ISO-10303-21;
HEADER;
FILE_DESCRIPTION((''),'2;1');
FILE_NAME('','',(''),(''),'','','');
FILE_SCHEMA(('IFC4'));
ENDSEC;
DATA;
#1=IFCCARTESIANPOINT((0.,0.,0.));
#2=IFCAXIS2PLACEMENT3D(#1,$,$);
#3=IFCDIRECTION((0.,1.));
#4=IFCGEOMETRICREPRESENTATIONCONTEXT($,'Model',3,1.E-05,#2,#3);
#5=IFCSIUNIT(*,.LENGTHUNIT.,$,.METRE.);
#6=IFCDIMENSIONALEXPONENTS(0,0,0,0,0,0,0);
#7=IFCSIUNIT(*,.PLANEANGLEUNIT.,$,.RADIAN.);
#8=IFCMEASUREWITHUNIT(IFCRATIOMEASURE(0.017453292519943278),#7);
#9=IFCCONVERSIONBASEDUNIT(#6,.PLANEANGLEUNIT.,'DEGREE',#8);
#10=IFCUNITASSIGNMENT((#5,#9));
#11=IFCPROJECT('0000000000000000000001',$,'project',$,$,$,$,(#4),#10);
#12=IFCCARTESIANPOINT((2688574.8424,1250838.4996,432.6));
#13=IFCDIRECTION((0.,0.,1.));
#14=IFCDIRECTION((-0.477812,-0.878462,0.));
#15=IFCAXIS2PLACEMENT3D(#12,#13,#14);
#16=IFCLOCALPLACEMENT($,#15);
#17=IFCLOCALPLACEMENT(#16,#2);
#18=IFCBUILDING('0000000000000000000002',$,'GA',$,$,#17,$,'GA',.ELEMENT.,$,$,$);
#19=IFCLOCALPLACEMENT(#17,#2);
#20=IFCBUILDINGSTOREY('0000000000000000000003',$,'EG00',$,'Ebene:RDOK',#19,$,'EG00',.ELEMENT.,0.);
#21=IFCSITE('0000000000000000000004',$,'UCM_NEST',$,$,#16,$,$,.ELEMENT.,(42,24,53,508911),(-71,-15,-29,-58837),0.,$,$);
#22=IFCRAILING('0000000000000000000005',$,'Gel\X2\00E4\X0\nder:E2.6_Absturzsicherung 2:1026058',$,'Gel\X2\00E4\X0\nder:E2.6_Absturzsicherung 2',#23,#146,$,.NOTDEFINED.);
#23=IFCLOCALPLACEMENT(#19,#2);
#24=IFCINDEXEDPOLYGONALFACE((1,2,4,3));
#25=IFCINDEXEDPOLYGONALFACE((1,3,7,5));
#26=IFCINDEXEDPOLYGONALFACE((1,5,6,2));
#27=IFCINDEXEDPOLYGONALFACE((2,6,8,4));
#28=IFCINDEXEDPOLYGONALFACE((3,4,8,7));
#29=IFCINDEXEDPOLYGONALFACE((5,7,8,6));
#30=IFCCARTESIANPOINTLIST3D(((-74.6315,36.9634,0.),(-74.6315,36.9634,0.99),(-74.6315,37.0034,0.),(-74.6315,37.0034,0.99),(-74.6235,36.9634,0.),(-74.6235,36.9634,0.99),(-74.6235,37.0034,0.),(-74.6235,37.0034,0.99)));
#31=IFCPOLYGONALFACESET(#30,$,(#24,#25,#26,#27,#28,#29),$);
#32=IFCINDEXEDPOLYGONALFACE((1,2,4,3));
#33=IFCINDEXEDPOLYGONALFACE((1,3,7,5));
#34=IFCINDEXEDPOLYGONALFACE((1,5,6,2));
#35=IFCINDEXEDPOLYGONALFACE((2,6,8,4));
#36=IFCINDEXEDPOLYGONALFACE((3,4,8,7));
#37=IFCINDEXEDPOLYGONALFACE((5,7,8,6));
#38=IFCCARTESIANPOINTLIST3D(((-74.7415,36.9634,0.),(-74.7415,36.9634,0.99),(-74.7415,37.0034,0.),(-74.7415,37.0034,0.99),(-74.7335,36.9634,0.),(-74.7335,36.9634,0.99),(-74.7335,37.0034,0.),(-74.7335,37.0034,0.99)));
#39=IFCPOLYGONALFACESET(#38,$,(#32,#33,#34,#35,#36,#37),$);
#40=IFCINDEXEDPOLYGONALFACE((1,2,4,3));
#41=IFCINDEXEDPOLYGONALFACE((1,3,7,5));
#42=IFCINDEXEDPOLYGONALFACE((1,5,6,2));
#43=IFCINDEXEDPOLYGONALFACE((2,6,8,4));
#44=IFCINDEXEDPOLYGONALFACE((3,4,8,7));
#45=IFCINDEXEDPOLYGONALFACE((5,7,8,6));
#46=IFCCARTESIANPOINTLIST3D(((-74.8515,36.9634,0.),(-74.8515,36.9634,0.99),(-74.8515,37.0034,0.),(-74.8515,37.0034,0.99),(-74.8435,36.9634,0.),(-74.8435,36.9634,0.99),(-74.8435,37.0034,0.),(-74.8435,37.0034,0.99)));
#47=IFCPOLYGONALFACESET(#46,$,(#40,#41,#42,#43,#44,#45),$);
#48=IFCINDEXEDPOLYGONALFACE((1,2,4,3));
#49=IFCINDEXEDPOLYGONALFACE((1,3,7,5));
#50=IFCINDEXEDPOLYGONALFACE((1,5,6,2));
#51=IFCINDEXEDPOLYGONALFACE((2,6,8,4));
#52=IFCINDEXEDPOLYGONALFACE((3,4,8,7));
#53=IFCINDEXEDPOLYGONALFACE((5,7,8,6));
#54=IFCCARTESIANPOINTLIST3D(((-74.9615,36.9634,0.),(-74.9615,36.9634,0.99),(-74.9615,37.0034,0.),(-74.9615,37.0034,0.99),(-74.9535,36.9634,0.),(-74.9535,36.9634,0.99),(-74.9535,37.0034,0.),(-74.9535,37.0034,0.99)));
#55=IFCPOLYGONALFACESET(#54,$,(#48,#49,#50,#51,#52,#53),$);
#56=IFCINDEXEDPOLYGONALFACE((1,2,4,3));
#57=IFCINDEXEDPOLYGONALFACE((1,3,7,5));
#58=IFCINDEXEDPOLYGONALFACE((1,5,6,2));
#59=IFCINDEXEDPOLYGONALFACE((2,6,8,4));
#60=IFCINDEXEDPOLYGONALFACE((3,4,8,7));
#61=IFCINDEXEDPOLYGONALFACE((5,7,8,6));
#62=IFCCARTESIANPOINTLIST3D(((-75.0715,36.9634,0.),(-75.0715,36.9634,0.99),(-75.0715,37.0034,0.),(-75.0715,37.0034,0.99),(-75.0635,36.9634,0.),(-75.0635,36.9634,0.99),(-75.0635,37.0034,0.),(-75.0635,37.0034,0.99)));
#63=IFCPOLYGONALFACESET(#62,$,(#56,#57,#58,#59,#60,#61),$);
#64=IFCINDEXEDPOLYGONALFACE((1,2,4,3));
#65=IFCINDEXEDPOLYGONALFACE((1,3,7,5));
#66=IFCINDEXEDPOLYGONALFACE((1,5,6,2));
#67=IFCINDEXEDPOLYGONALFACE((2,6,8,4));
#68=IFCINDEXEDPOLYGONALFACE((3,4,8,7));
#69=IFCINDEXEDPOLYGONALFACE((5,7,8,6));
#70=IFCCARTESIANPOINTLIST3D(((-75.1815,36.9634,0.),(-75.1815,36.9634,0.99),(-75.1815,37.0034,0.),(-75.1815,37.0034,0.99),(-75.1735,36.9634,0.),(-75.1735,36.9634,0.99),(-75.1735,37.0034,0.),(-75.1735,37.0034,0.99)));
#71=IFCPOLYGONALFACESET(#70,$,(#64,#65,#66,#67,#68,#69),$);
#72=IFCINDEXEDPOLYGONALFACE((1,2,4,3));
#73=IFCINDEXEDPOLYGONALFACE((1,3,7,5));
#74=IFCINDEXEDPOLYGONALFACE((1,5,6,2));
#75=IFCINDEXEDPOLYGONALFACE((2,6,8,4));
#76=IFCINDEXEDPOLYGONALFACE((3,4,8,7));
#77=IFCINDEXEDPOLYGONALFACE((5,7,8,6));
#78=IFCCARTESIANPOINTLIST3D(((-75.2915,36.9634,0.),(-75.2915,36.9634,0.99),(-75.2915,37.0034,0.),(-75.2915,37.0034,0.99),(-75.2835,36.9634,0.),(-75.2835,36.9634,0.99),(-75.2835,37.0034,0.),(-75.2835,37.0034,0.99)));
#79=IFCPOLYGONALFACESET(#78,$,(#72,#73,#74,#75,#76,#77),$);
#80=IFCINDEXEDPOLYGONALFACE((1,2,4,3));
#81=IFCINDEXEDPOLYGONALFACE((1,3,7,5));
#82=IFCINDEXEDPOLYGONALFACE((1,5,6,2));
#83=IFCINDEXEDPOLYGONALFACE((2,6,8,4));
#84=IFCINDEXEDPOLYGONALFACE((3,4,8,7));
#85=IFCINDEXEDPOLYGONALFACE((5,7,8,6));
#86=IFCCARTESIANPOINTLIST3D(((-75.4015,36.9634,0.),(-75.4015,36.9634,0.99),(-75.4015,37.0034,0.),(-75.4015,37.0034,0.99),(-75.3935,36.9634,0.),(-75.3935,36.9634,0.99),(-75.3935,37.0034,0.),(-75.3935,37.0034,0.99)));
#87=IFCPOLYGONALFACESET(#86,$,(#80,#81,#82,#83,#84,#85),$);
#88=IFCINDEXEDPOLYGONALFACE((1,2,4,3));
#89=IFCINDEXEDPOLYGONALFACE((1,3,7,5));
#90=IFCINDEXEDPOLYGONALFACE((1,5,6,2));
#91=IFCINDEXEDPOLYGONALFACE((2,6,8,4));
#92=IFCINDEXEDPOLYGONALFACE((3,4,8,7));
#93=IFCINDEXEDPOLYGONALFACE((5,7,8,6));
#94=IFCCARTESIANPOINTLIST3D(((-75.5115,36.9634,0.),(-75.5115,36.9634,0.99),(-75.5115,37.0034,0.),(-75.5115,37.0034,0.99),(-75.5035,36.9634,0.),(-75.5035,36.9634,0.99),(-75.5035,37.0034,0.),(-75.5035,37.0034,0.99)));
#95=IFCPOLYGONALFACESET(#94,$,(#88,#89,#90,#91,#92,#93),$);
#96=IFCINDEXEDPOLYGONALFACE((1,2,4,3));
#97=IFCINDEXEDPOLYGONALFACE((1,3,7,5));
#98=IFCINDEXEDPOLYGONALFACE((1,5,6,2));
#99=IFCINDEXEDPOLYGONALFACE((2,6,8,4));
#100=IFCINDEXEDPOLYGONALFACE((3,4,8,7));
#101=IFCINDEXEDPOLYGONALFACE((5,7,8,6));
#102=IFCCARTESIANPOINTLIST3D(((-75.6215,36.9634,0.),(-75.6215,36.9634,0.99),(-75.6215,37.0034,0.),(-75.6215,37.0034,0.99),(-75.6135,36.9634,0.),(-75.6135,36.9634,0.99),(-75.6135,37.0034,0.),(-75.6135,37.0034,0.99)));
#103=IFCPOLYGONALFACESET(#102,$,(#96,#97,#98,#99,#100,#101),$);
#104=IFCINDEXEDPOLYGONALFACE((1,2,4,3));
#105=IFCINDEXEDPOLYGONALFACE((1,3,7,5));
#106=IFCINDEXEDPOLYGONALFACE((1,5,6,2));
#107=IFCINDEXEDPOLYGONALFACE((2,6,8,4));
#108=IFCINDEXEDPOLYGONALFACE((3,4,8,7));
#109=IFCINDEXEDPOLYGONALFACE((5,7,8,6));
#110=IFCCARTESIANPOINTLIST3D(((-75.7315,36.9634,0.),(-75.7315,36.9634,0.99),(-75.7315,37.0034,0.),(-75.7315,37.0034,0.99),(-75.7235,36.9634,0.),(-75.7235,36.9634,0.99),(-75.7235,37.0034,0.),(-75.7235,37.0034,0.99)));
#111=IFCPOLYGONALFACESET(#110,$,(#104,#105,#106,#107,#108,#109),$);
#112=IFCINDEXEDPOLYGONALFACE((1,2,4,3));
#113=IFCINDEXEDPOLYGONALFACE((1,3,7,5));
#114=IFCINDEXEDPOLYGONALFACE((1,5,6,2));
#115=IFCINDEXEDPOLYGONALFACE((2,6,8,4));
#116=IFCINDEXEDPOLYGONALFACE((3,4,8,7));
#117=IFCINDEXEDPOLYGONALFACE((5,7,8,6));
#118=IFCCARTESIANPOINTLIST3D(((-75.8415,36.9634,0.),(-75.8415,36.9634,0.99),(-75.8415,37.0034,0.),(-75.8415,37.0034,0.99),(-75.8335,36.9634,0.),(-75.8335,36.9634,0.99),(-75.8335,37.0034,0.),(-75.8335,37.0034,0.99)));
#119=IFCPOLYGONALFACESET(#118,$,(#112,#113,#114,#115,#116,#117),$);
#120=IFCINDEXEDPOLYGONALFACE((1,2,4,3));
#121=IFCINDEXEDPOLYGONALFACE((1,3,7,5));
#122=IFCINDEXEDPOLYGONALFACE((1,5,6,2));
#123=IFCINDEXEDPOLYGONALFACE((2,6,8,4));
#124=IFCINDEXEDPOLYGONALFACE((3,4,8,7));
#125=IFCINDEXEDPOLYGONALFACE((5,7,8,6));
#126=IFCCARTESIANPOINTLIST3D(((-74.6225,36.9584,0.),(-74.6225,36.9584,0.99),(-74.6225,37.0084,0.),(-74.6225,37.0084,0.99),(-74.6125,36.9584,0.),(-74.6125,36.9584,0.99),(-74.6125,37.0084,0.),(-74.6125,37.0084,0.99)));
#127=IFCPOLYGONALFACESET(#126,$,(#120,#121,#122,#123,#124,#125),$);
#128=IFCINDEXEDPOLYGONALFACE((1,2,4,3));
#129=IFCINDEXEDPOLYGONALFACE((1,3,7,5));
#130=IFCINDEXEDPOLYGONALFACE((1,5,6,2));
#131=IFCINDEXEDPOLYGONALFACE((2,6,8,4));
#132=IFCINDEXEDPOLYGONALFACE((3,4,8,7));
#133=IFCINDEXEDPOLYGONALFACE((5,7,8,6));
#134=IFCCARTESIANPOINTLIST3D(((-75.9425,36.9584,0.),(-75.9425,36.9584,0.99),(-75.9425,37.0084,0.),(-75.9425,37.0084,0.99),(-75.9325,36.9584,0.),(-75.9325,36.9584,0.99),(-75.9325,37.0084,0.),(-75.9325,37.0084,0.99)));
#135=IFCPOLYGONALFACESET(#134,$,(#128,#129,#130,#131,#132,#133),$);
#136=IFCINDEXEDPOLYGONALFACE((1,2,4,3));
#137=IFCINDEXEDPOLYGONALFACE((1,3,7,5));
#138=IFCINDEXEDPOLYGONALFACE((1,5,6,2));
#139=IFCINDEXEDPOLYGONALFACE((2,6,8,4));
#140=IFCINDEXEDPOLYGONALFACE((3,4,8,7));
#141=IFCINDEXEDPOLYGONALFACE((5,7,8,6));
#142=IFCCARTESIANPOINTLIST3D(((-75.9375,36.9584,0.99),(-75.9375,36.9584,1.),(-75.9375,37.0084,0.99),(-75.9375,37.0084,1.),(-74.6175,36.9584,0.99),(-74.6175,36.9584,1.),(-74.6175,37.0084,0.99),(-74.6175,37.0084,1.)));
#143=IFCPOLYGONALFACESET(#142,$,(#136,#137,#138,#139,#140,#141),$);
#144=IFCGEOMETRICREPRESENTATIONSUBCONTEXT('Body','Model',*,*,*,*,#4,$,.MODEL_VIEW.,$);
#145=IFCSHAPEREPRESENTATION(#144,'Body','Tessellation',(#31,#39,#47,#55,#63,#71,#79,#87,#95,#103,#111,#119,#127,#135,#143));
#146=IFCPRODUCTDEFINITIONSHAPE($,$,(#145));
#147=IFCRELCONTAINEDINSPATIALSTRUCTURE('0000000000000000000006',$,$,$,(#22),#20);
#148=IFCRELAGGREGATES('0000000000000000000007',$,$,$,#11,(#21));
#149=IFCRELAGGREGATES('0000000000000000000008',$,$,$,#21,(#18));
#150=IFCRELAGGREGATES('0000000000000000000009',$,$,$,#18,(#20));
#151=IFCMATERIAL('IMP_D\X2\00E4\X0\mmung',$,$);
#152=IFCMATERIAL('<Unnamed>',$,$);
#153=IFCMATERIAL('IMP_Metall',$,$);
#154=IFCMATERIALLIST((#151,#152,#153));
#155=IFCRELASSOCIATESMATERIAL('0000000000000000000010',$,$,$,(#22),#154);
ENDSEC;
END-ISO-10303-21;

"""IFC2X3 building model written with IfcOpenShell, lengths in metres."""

from ifc_helpers import new_model, entity, si_unit, converted_unit, direction, frame, origin, origin_2d_with_axis, place, context, subcontext, project, spatial, rectangle, extrude, material, material_list, element, save


model = new_model("IFC2X3")

# Units and contexts
model_context = context("Model", 3, precision=1e-05, world=origin(), true_north=direction((0.0, 1.0)))
body_context = subcontext(model_context, "Body", "Model", "MODEL_VIEW")
ifc_project = project(units=[si_unit("LENGTHUNIT", "METRE"), converted_unit("PLANEANGLEUNIT", "DEGREE", entity("IfcRatioMeasure", 0.017453292519943278), si_unit("PLANEANGLEUNIT", "RADIAN"), dimensions=[0, 0, 0, 0, 0, 0, 0])], contexts=[model_context])

# Site, building, storey
site_placement = place(None, frame((2688574.8424, 1250838.4996, 432.6), z_axis=(0.0, 0.0, 1.0), x_axis=(-0.477812, -0.878462, 0.0)))
site = spatial("IfcSite", under=ifc_project, at=site_placement, Name="UCM_NEST", CompositionType="ELEMENT", RefLatitude=(42, 24, 53, 508911), RefLongitude=(-71, -15, -29, -58837), RefElevation=0.0)
building_placement = place(site_placement, origin())
building = spatial("IfcBuilding", under=site, at=building_placement, Name="GA", LongName="GA", CompositionType="ELEMENT")
storey_placement = place(building_placement, origin())
storey = spatial("IfcBuildingStorey", under=building, at=storey_placement, Name="EG00", ObjectType="Ebene:RDOK", LongName="EG00", CompositionType="ELEMENT", Elevation=0.0)

# Shared definitions
ifc_material_1 = material(Name="IMP_Dämmung")

# Railing
ifc_material_2 = material(Name="<Unnamed>")
ifc_material_3 = material(Name="IMP_Metall")
ifc_material_list = material_list([ifc_material_1, ifc_material_2, ifc_material_3])
railing_1_placement = place(storey_placement, origin())
element("IfcRailing", 1, at=railing_1_placement, inside=storey, material=ifc_material_list, Name="Geländer:E2.6_Absturzsicherung 2:1026058", ObjectType="Geländer:E2.6_Absturzsicherung 2", PredefinedType="NOTDEFINED", context=body_context, shape_type="SweptSolid", body=[
    extrude(rectangle(XDim=0.008, YDim=0.04, at=origin_2d_with_axis()), frame((-74.6275, 36.9834, 0.0)), (0.0, 0.0, 1.0), 0.99),
    extrude(rectangle(XDim=0.008, YDim=0.04, at=origin_2d_with_axis()), frame((-74.7375, 36.9834, 0.0)), (0.0, 0.0, 1.0), 0.99),
    extrude(rectangle(XDim=0.008, YDim=0.04, at=origin_2d_with_axis()), frame((-74.8475, 36.9834, 0.0)), (0.0, 0.0, 1.0), 0.99),
    extrude(rectangle(XDim=0.008, YDim=0.04, at=origin_2d_with_axis()), frame((-74.9575, 36.9834, 0.0)), (0.0, 0.0, 1.0), 0.99),
    extrude(rectangle(XDim=0.008, YDim=0.04, at=origin_2d_with_axis()), frame((-75.0675, 36.9834, 0.0)), (0.0, 0.0, 1.0), 0.99),
    extrude(rectangle(XDim=0.008, YDim=0.04, at=origin_2d_with_axis()), frame((-75.1775, 36.9834, 0.0)), (0.0, 0.0, 1.0), 0.99),
    extrude(rectangle(XDim=0.008, YDim=0.04, at=origin_2d_with_axis()), frame((-75.2875, 36.9834, 0.0)), (0.0, 0.0, 1.0), 0.99),
    extrude(rectangle(XDim=0.008, YDim=0.04, at=origin_2d_with_axis()), frame((-75.3975, 36.9834, 0.0)), (0.0, 0.0, 1.0), 0.99),
    extrude(rectangle(XDim=0.008, YDim=0.04, at=origin_2d_with_axis()), frame((-75.5075, 36.9834, 0.0)), (0.0, 0.0, 1.0), 0.99),
    extrude(rectangle(XDim=0.008, YDim=0.04, at=origin_2d_with_axis()), frame((-75.6175, 36.9834, 0.0)), (0.0, 0.0, 1.0), 0.99),
    extrude(rectangle(XDim=0.008, YDim=0.04, at=origin_2d_with_axis()), frame((-75.7275, 36.9834, 0.0)), (0.0, 0.0, 1.0), 0.99),
    extrude(rectangle(XDim=0.008, YDim=0.04, at=origin_2d_with_axis()), frame((-75.8375, 36.9834, 0.0)), (0.0, 0.0, 1.0), 0.99),
    extrude(rectangle(XDim=0.01, YDim=0.05, at=origin_2d_with_axis()), frame((-74.6175, 36.9834, 0.0)), (0.0, 0.0, 1.0), 0.99),
    extrude(rectangle(XDim=0.01, YDim=0.05, at=origin_2d_with_axis()), frame((-75.9375, 36.9834, 0.0)), (0.0, 0.0, 1.0), 0.99),
    extrude(rectangle(XDim=1.32, YDim=0.05, at=origin_2d_with_axis()), frame((-75.2775, 36.9834, 0.99)), (0.0, 0.0, 1.0), 0.01),
])

save(model, "model.ifc")
